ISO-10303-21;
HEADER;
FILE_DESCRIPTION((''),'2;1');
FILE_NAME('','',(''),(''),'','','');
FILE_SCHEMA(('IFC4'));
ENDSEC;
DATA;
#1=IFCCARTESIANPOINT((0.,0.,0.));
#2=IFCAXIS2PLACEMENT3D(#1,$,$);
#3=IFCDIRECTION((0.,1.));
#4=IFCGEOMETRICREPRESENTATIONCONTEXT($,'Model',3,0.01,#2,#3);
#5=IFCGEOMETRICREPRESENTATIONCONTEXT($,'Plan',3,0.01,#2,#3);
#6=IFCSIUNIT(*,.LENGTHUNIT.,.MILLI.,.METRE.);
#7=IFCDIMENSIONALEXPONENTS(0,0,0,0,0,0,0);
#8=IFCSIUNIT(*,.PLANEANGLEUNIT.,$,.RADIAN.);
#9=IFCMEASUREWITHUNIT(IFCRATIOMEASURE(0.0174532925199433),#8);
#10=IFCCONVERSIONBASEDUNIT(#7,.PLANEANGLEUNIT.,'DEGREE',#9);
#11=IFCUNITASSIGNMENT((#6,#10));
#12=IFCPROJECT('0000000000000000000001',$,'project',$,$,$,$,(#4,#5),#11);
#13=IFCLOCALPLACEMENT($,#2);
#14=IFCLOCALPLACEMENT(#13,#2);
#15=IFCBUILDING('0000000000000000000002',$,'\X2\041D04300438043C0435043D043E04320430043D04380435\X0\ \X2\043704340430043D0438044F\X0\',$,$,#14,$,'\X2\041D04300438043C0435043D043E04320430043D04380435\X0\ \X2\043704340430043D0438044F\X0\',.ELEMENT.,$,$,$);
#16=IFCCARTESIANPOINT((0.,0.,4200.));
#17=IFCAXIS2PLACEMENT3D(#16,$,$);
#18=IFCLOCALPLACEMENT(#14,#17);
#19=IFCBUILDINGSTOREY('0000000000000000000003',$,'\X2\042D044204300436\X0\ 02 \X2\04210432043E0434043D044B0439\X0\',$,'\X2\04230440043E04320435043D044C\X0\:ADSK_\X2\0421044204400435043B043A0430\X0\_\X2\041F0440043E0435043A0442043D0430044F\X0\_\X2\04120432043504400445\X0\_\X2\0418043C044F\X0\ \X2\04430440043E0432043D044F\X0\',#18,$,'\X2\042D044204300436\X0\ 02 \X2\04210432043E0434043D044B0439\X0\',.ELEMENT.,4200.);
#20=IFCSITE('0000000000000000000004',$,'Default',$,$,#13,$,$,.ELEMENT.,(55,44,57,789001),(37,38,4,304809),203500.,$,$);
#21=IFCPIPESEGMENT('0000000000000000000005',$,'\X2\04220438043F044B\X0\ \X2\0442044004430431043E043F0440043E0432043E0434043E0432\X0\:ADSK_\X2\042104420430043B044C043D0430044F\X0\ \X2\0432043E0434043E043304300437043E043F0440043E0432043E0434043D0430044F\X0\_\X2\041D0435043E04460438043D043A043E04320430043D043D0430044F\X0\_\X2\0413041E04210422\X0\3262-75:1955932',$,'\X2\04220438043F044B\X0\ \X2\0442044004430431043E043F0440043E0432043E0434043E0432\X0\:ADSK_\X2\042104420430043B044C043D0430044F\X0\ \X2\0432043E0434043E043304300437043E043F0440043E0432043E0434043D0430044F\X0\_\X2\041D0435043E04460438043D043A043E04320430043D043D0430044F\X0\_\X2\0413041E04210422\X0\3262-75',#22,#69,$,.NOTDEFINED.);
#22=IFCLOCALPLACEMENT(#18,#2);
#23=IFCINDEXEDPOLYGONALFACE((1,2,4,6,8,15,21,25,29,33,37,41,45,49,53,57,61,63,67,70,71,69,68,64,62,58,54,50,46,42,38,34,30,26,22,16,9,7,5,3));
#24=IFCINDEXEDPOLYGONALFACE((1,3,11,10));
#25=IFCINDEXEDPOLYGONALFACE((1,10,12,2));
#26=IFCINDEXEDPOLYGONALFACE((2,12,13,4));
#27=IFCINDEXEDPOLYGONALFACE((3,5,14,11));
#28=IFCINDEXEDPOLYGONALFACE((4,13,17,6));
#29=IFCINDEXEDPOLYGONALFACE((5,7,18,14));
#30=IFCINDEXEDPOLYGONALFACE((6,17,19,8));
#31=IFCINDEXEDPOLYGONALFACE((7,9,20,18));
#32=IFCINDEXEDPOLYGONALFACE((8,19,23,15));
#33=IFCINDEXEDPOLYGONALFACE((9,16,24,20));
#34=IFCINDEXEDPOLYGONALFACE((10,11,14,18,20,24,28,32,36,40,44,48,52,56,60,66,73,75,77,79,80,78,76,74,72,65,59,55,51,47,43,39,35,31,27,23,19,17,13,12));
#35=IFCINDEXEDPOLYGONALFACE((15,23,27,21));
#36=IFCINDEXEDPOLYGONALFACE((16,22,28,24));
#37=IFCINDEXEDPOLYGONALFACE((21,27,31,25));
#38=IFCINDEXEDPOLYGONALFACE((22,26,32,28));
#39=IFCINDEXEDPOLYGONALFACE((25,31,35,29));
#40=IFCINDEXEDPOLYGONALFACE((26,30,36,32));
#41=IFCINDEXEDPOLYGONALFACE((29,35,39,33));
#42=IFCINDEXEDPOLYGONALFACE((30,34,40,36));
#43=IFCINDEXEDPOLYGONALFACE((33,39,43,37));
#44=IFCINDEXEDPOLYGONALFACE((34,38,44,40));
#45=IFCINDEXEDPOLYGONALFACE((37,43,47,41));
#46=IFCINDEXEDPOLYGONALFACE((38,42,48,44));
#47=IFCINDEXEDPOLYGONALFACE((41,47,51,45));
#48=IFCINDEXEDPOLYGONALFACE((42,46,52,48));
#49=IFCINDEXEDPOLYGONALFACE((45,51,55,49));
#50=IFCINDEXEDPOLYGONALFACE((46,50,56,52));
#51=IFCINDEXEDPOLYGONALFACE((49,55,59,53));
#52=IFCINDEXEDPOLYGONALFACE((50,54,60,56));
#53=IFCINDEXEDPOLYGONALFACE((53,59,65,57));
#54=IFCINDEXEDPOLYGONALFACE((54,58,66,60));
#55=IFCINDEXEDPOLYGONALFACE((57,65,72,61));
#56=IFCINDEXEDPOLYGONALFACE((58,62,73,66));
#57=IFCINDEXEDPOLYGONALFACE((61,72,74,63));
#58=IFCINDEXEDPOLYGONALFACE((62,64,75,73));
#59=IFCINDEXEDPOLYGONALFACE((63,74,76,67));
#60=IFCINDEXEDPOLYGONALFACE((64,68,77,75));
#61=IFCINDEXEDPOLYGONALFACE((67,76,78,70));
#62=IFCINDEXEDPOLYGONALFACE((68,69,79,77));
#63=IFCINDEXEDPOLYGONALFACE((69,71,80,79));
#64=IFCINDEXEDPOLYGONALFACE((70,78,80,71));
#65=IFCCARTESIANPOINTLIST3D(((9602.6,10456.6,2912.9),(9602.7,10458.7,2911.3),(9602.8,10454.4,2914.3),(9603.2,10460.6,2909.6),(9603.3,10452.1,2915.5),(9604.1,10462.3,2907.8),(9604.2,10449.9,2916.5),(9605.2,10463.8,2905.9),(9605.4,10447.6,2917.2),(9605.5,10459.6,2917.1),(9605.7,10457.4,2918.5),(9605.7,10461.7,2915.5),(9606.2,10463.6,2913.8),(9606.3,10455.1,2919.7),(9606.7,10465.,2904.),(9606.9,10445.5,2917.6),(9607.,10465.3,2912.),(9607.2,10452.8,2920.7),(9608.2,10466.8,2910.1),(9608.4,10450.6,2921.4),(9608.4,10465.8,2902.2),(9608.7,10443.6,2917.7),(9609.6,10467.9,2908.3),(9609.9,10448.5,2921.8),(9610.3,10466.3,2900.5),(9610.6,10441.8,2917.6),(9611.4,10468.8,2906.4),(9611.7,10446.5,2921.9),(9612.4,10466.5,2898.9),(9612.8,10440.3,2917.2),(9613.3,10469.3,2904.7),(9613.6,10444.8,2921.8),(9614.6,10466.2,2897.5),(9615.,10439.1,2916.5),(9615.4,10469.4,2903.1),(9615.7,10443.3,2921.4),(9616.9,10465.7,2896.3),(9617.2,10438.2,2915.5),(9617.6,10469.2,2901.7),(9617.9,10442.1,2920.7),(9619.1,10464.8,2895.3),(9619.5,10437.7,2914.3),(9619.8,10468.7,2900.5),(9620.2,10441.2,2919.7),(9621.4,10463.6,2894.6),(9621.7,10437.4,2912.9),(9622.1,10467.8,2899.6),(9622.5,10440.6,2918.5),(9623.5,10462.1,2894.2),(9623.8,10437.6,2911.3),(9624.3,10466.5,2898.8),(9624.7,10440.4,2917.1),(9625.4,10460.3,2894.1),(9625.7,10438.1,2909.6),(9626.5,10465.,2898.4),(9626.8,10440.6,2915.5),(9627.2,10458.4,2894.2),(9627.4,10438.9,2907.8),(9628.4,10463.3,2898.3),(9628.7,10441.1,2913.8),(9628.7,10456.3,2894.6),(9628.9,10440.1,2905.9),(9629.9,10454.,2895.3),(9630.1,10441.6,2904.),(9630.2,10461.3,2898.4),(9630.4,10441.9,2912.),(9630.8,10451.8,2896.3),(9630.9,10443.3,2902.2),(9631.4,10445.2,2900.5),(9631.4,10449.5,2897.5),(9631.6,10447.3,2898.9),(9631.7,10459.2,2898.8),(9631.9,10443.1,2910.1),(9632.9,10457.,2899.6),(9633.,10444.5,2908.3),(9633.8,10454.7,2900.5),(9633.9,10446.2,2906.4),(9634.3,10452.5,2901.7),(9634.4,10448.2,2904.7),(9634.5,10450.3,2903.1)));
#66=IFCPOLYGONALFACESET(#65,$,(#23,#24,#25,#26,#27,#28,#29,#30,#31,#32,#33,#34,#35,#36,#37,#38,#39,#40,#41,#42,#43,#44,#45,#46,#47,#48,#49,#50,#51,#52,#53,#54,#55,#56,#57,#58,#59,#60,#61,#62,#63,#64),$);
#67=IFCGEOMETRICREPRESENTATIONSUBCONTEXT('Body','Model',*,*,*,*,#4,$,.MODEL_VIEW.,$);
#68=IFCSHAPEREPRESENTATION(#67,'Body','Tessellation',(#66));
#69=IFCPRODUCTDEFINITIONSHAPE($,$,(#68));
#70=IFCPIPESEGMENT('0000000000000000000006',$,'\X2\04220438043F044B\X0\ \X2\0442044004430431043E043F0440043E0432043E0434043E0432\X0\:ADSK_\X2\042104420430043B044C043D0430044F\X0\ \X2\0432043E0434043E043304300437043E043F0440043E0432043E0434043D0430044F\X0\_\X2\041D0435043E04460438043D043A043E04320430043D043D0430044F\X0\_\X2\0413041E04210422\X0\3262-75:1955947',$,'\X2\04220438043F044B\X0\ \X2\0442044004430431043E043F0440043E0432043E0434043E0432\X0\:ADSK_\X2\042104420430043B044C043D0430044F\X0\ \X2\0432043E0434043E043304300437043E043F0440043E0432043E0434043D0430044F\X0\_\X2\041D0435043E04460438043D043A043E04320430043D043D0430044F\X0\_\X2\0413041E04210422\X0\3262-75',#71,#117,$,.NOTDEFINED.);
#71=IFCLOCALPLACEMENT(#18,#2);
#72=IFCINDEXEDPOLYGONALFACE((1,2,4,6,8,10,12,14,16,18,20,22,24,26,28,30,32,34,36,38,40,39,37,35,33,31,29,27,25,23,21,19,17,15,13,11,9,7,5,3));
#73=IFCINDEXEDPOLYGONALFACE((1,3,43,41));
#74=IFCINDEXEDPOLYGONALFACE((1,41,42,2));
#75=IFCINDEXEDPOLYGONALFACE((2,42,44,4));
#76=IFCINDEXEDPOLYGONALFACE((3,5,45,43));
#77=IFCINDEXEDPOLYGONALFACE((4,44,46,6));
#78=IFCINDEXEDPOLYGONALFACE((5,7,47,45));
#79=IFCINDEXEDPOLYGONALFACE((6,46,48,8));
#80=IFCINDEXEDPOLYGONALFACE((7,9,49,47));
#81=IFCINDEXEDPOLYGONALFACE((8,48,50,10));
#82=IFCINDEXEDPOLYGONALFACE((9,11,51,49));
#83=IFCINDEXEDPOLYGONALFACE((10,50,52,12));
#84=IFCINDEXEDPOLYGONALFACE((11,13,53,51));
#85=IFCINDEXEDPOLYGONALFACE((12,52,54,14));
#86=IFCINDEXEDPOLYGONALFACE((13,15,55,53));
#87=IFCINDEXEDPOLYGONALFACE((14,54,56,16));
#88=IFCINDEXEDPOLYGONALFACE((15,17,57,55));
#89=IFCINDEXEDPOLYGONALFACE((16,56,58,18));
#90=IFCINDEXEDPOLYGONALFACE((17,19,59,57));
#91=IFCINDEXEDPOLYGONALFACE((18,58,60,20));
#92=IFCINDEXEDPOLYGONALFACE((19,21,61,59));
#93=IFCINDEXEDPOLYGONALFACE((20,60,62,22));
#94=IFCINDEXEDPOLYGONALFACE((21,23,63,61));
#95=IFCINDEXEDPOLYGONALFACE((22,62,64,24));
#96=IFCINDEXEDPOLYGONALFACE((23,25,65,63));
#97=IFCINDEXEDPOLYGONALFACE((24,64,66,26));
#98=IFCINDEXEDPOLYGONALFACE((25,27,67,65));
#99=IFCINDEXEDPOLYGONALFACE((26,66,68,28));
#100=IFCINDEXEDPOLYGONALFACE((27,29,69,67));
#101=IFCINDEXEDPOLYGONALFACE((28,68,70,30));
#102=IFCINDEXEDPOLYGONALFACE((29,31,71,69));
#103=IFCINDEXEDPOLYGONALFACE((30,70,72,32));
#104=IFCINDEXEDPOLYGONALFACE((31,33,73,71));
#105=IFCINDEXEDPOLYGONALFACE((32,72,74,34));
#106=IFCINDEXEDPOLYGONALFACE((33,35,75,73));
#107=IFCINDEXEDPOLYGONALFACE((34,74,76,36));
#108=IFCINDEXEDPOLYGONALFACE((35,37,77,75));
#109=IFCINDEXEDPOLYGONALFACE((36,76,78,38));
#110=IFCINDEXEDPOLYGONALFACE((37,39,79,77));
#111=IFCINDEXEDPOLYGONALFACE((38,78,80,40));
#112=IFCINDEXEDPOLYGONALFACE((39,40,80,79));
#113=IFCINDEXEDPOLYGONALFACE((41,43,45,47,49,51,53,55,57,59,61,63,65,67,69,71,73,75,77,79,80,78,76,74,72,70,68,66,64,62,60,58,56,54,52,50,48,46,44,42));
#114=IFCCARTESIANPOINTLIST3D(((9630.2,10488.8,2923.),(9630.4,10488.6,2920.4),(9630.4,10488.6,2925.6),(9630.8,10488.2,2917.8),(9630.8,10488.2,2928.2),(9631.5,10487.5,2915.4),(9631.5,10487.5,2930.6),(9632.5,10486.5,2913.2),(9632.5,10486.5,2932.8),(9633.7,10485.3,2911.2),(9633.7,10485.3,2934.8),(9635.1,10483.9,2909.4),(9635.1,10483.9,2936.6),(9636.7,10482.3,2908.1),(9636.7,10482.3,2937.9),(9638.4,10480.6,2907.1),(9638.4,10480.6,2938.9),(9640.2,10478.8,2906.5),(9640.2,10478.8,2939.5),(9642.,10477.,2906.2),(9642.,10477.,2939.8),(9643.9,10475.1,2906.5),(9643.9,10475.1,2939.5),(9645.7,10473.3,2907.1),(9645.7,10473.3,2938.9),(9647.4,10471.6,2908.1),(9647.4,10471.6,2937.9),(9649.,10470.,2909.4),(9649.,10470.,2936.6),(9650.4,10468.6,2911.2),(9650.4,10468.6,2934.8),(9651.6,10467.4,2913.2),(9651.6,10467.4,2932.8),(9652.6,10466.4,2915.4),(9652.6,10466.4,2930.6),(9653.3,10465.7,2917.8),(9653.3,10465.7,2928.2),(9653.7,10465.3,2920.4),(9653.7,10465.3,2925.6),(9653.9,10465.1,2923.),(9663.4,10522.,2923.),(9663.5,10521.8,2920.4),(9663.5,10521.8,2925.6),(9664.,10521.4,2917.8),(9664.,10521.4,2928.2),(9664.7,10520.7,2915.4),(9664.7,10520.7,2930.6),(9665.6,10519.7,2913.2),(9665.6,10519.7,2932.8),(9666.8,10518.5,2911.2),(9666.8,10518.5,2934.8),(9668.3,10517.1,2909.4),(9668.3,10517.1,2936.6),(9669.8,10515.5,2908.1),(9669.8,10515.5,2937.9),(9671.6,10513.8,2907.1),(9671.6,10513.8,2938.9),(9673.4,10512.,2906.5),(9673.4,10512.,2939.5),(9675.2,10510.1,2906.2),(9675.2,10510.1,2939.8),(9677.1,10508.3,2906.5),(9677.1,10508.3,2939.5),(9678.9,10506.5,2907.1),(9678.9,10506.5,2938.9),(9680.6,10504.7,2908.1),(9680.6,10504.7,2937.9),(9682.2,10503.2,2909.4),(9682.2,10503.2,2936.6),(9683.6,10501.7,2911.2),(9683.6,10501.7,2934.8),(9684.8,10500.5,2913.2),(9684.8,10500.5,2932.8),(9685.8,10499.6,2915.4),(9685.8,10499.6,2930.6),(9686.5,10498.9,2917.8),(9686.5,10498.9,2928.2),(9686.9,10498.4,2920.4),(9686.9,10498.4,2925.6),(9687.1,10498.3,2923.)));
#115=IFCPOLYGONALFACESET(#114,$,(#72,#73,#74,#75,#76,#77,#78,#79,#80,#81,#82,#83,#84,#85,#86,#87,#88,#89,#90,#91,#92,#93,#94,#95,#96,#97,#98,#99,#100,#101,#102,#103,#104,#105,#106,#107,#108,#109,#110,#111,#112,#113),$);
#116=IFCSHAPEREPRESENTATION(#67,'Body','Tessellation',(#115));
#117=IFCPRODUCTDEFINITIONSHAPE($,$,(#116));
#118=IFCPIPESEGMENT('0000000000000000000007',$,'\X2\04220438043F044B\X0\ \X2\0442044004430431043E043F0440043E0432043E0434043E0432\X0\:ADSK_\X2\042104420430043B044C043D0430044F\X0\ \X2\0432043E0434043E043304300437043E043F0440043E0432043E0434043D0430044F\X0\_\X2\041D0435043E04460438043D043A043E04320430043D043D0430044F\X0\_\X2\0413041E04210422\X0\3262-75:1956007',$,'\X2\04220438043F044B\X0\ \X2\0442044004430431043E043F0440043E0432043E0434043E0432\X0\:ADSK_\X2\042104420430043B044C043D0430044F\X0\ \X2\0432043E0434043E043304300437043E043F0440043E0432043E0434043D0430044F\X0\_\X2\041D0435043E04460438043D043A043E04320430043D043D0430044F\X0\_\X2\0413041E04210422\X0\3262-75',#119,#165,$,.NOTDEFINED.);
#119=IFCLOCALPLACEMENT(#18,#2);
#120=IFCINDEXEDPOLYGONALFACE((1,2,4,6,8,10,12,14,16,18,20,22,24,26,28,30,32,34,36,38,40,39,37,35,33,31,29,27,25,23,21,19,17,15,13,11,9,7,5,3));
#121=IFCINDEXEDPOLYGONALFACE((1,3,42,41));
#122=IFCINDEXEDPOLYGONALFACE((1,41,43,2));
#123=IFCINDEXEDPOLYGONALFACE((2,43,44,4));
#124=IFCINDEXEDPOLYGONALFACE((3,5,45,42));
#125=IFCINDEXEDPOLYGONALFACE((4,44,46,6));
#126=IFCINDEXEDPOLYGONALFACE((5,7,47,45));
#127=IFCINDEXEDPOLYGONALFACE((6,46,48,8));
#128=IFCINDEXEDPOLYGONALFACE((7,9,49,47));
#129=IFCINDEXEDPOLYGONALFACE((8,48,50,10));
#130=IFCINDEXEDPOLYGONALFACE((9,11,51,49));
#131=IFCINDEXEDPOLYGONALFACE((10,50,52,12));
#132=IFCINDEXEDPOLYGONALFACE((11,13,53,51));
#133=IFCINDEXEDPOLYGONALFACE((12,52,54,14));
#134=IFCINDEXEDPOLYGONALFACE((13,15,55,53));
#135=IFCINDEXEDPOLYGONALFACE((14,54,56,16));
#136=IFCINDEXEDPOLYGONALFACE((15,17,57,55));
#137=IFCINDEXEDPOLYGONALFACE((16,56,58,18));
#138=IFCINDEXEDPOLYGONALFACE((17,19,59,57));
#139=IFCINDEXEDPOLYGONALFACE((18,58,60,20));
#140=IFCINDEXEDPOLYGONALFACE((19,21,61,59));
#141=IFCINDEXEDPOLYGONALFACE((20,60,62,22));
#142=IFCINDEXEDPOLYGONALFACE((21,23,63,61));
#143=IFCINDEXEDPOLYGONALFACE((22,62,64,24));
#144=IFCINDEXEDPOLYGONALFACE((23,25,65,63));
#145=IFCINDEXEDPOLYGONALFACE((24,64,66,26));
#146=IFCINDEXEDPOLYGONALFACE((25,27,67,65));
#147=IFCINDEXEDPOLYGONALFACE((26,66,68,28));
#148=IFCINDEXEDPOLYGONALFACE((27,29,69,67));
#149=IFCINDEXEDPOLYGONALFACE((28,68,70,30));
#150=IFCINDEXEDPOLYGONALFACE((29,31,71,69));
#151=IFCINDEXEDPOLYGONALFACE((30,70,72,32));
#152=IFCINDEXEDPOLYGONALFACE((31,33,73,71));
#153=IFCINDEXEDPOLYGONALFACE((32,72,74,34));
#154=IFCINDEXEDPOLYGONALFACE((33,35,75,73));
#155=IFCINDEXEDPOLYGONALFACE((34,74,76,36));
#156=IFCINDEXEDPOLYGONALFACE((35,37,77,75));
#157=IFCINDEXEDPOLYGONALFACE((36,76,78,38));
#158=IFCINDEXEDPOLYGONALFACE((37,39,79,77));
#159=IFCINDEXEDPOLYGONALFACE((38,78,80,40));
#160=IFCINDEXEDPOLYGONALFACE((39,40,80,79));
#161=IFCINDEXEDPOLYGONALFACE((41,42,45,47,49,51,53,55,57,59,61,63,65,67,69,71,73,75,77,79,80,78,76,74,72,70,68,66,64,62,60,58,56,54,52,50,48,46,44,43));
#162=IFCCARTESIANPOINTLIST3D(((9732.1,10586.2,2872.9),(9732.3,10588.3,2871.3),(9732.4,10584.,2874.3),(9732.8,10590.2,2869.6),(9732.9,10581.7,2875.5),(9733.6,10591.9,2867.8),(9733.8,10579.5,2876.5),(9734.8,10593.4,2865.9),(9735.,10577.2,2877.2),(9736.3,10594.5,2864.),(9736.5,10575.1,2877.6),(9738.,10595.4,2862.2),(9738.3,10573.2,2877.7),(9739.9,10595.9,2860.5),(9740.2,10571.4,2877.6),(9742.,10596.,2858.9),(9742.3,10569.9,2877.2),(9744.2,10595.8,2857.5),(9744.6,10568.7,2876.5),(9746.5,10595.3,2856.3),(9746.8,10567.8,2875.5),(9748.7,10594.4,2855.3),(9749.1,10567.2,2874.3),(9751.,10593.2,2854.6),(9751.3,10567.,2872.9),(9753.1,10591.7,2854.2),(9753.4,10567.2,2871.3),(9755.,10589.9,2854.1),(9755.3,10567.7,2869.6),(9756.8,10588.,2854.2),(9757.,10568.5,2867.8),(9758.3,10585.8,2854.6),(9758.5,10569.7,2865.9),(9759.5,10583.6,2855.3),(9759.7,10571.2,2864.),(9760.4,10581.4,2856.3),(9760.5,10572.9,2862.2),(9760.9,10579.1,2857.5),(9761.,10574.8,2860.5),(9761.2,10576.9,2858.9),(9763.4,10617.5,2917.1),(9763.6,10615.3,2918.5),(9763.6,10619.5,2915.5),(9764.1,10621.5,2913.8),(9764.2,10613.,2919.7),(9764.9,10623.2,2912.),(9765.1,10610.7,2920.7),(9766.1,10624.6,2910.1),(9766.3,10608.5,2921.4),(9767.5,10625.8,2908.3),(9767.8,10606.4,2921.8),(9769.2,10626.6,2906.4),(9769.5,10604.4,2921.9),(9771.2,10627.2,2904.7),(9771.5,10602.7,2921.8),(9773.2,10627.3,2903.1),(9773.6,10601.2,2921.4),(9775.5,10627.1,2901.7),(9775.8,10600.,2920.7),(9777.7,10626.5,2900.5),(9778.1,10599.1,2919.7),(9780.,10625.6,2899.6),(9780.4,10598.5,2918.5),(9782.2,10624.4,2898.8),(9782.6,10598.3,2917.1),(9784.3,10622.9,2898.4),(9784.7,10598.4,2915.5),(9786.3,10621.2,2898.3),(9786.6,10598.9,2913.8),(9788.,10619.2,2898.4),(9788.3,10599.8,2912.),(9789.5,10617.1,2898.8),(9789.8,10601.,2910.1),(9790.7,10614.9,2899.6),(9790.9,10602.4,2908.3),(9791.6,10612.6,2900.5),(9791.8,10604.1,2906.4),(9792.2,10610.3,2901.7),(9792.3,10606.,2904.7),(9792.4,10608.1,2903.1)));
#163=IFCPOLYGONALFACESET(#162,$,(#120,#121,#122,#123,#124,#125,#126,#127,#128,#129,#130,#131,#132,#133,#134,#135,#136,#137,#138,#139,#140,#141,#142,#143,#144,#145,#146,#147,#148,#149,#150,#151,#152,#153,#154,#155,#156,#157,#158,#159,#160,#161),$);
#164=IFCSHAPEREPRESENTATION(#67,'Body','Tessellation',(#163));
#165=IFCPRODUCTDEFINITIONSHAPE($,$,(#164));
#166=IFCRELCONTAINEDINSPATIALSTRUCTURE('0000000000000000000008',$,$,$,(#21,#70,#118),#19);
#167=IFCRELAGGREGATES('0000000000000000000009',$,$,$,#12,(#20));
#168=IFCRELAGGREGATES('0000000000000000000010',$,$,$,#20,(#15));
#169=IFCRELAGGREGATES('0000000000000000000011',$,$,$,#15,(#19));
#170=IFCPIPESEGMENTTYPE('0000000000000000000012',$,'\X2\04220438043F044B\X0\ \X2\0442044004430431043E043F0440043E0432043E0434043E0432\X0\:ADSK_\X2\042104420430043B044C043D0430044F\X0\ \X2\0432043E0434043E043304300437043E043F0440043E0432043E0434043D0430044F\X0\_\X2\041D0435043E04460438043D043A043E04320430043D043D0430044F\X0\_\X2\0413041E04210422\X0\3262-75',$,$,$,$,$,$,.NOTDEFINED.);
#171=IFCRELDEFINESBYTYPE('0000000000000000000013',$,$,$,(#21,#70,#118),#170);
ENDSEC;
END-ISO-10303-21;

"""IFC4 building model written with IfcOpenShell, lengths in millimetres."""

from ifc_helpers import new_model, entity, si_unit, converted_unit, direction, frame, origin, place, context, subcontext, project, spatial, indexed_curve, outline, extrude, type_object, element, save


model = new_model("IFC4")

# Units and contexts
model_context = context("Model", 3, precision=0.01, world=origin(), true_north=direction((0.0, 1.0)))
plan_context = context("Plan", 3, precision=0.01, world=origin(), true_north=direction((0.0, 1.0)))
body_context = subcontext(model_context, "Body", "Model", "MODEL_VIEW")
ifc_project = project(units=[si_unit("LENGTHUNIT", "METRE", prefix="MILLI"), converted_unit("PLANEANGLEUNIT", "DEGREE", entity("IfcRatioMeasure", 0.0174532925199433), si_unit("PLANEANGLEUNIT", "RADIAN"), dimensions=[0, 0, 0, 0, 0, 0, 0])], contexts=[model_context, plan_context])

# Site, building, storey
site_placement = place(None, origin())
site = spatial("IfcSite", under=ifc_project, at=site_placement, Name="Default", CompositionType="ELEMENT", RefLatitude=(55, 44, 57, 789001), RefLongitude=(37, 38, 4, 304809), RefElevation=203500.0)
building_placement = place(site_placement, origin())
building = spatial("IfcBuilding", under=site, at=building_placement, Name="Наименование здания", LongName="Наименование здания", CompositionType="ELEMENT")
storey_placement = place(building_placement, frame((0.0, 0.0, 4200.0)))
storey = spatial("IfcBuildingStorey", under=building, at=storey_placement, Name="Этаж 02 Сводный", ObjectType="Уровень:ADSK_Стрелка_Проектная_Вверх_Имя уровня", LongName="Этаж 02 Сводный", CompositionType="ELEMENT", Elevation=4200.0)

# Pipe segments
placement = place(storey_placement, origin())
pipe_segment_type_1 = type_object("IfcPipeSegmentType", Name="Типы трубопроводов:ADSK_Стальная водогазопроводная_Неоцинкованная_ГОСТ3262-75", PredefinedType="NOTDEFINED")
element("IfcPipeSegment", 1, at=placement, inside=storey, type_object=pipe_segment_type_1, Name="Типы трубопроводов:ADSK_Стальная водогазопроводная_Неоцинкованная_ГОСТ3262-75:1955932", ObjectType="Типы трубопроводов:ADSK_Стальная водогазопроводная_Неоцинкованная_ГОСТ3262-75", PredefinedType="NOTDEFINED", context=body_context, shape_type="SweptSolid", body=[
    extrude(outline(indexed_curve([(16.8, 0.0), (16.5, 2.6), (15.9, 5.2), (14.9, 7.6), (13.6, 9.8), (11.8, 11.8), (9.8, 13.6), (7.6, 14.9), (5.2, 15.9), (2.6, 16.5), (0.0, 16.8), (-2.6, 16.5), (-5.2, 15.9), (-7.6, 14.9), (-9.8, 13.6), (-11.8, 11.8), (-13.6, 9.8), (-14.9, 7.6), (-15.9, 5.2), (-16.5, 2.6), (-16.8, 0.0), (-16.5, -2.6), (-15.9, -5.2), (-14.9, -7.6), (-13.6, -9.8), (-11.8, -11.8), (-9.8, -13.6), (-7.6, -14.9), (-5.2, -15.9), (-2.6, -16.5), (0.0, -16.8), (2.6, -16.5), (5.2, -15.9), (7.6, -14.9), (9.8, -13.6), (11.8, -11.8), (13.6, -9.8), (14.9, -7.6), (15.9, -5.2), (16.5, -2.6), (16.8, 0.0)], self_intersect=False)), frame((9617.1, 10452.0, 2905.9), z_axis=(0.5, 0.5, 0.707107), x_axis=(0.707107, -0.707107, 0.0)), (0.0, 0.0, 1.0), 5.9),
])
element("IfcPipeSegment", 2, at=placement, inside=storey, type_object=pipe_segment_type_1, Name="Типы трубопроводов:ADSK_Стальная водогазопроводная_Неоцинкованная_ГОСТ3262-75:1955947", ObjectType="Типы трубопроводов:ADSK_Стальная водогазопроводная_Неоцинкованная_ГОСТ3262-75", PredefinedType="NOTDEFINED", context=body_context, shape_type="SweptSolid", body=[
    extrude(outline(indexed_curve([(16.8, 0.0), (16.5, 2.6), (15.9, 5.2), (14.9, 7.6), (13.6, 9.8), (11.8, 11.8), (9.8, 13.6), (7.6, 14.9), (5.2, 15.9), (2.6, 16.5), (0.0, 16.8), (-2.6, 16.5), (-5.2, 15.9), (-7.6, 14.9), (-9.8, 13.6), (-11.8, 11.8), (-13.6, 9.8), (-14.9, 7.6), (-15.9, 5.2), (-16.5, 2.6), (-16.8, 0.0), (-16.5, -2.6), (-15.9, -5.2), (-14.9, -7.6), (-13.6, -9.8), (-11.8, -11.8), (-9.8, -13.6), (-7.6, -14.9), (-5.2, -15.9), (-2.6, -16.5), (0.0, -16.8), (2.6, -16.5), (5.2, -15.9), (7.6, -14.9), (9.8, -13.6), (11.8, -11.8), (13.6, -9.8), (14.9, -7.6), (15.9, -5.2), (16.5, -2.6), (16.8, 0.0)], self_intersect=False)), frame((9642.0, 10477.0, 2923.0), z_axis=(0.707107, 0.707107, 0.0), x_axis=(-0.707107, 0.707107, 0.0)), (0.0, 0.0, 1.0), 46.9),
])
element("IfcPipeSegment", 3, at=placement, inside=storey, type_object=pipe_segment_type_1, Name="Типы трубопроводов:ADSK_Стальная водогазопроводная_Неоцинкованная_ГОСТ3262-75:1956007", ObjectType="Типы трубопроводов:ADSK_Стальная водогазопроводная_Неоцинкованная_ГОСТ3262-75", PredefinedType="NOTDEFINED", context=body_context, shape_type="SweptSolid", body=[
    extrude(outline(indexed_curve([(16.7, 0.0), (16.5, 2.6), (15.9, 5.2), (14.9, 7.6), (13.6, 9.8), (11.8, 11.8), (9.8, 13.6), (7.6, 14.9), (5.2, 15.9), (2.6, 16.5), (0.0, 16.8), (-2.6, 16.5), (-5.2, 15.9), (-7.6, 14.9), (-9.8, 13.6), (-11.8, 11.8), (-13.6, 9.8), (-14.9, 7.6), (-15.9, 5.2), (-16.5, 2.6), (-16.7, 0.0), (-16.5, -2.6), (-15.9, -5.2), (-14.9, -7.6), (-13.6, -9.8), (-11.8, -11.8), (-9.8, -13.6), (-7.6, -14.9), (-5.2, -15.9), (-2.6, -16.5), (0.0, -16.8), (2.6, -16.5), (5.2, -15.9), (7.6, -14.9), (9.8, -13.6), (11.8, -11.8), (13.6, -9.8), (14.9, -7.6), (15.9, -5.2), (16.5, -2.6), (16.7, 0.0)], self_intersect=False)), frame((9746.6, 10581.5, 2865.9), z_axis=(0.5, 0.5, 0.707107), x_axis=(-0.707107, 0.707107, 0.0)), (0.0, 0.0, 1.0), 62.5),
])

save(model, "model.ifc")
